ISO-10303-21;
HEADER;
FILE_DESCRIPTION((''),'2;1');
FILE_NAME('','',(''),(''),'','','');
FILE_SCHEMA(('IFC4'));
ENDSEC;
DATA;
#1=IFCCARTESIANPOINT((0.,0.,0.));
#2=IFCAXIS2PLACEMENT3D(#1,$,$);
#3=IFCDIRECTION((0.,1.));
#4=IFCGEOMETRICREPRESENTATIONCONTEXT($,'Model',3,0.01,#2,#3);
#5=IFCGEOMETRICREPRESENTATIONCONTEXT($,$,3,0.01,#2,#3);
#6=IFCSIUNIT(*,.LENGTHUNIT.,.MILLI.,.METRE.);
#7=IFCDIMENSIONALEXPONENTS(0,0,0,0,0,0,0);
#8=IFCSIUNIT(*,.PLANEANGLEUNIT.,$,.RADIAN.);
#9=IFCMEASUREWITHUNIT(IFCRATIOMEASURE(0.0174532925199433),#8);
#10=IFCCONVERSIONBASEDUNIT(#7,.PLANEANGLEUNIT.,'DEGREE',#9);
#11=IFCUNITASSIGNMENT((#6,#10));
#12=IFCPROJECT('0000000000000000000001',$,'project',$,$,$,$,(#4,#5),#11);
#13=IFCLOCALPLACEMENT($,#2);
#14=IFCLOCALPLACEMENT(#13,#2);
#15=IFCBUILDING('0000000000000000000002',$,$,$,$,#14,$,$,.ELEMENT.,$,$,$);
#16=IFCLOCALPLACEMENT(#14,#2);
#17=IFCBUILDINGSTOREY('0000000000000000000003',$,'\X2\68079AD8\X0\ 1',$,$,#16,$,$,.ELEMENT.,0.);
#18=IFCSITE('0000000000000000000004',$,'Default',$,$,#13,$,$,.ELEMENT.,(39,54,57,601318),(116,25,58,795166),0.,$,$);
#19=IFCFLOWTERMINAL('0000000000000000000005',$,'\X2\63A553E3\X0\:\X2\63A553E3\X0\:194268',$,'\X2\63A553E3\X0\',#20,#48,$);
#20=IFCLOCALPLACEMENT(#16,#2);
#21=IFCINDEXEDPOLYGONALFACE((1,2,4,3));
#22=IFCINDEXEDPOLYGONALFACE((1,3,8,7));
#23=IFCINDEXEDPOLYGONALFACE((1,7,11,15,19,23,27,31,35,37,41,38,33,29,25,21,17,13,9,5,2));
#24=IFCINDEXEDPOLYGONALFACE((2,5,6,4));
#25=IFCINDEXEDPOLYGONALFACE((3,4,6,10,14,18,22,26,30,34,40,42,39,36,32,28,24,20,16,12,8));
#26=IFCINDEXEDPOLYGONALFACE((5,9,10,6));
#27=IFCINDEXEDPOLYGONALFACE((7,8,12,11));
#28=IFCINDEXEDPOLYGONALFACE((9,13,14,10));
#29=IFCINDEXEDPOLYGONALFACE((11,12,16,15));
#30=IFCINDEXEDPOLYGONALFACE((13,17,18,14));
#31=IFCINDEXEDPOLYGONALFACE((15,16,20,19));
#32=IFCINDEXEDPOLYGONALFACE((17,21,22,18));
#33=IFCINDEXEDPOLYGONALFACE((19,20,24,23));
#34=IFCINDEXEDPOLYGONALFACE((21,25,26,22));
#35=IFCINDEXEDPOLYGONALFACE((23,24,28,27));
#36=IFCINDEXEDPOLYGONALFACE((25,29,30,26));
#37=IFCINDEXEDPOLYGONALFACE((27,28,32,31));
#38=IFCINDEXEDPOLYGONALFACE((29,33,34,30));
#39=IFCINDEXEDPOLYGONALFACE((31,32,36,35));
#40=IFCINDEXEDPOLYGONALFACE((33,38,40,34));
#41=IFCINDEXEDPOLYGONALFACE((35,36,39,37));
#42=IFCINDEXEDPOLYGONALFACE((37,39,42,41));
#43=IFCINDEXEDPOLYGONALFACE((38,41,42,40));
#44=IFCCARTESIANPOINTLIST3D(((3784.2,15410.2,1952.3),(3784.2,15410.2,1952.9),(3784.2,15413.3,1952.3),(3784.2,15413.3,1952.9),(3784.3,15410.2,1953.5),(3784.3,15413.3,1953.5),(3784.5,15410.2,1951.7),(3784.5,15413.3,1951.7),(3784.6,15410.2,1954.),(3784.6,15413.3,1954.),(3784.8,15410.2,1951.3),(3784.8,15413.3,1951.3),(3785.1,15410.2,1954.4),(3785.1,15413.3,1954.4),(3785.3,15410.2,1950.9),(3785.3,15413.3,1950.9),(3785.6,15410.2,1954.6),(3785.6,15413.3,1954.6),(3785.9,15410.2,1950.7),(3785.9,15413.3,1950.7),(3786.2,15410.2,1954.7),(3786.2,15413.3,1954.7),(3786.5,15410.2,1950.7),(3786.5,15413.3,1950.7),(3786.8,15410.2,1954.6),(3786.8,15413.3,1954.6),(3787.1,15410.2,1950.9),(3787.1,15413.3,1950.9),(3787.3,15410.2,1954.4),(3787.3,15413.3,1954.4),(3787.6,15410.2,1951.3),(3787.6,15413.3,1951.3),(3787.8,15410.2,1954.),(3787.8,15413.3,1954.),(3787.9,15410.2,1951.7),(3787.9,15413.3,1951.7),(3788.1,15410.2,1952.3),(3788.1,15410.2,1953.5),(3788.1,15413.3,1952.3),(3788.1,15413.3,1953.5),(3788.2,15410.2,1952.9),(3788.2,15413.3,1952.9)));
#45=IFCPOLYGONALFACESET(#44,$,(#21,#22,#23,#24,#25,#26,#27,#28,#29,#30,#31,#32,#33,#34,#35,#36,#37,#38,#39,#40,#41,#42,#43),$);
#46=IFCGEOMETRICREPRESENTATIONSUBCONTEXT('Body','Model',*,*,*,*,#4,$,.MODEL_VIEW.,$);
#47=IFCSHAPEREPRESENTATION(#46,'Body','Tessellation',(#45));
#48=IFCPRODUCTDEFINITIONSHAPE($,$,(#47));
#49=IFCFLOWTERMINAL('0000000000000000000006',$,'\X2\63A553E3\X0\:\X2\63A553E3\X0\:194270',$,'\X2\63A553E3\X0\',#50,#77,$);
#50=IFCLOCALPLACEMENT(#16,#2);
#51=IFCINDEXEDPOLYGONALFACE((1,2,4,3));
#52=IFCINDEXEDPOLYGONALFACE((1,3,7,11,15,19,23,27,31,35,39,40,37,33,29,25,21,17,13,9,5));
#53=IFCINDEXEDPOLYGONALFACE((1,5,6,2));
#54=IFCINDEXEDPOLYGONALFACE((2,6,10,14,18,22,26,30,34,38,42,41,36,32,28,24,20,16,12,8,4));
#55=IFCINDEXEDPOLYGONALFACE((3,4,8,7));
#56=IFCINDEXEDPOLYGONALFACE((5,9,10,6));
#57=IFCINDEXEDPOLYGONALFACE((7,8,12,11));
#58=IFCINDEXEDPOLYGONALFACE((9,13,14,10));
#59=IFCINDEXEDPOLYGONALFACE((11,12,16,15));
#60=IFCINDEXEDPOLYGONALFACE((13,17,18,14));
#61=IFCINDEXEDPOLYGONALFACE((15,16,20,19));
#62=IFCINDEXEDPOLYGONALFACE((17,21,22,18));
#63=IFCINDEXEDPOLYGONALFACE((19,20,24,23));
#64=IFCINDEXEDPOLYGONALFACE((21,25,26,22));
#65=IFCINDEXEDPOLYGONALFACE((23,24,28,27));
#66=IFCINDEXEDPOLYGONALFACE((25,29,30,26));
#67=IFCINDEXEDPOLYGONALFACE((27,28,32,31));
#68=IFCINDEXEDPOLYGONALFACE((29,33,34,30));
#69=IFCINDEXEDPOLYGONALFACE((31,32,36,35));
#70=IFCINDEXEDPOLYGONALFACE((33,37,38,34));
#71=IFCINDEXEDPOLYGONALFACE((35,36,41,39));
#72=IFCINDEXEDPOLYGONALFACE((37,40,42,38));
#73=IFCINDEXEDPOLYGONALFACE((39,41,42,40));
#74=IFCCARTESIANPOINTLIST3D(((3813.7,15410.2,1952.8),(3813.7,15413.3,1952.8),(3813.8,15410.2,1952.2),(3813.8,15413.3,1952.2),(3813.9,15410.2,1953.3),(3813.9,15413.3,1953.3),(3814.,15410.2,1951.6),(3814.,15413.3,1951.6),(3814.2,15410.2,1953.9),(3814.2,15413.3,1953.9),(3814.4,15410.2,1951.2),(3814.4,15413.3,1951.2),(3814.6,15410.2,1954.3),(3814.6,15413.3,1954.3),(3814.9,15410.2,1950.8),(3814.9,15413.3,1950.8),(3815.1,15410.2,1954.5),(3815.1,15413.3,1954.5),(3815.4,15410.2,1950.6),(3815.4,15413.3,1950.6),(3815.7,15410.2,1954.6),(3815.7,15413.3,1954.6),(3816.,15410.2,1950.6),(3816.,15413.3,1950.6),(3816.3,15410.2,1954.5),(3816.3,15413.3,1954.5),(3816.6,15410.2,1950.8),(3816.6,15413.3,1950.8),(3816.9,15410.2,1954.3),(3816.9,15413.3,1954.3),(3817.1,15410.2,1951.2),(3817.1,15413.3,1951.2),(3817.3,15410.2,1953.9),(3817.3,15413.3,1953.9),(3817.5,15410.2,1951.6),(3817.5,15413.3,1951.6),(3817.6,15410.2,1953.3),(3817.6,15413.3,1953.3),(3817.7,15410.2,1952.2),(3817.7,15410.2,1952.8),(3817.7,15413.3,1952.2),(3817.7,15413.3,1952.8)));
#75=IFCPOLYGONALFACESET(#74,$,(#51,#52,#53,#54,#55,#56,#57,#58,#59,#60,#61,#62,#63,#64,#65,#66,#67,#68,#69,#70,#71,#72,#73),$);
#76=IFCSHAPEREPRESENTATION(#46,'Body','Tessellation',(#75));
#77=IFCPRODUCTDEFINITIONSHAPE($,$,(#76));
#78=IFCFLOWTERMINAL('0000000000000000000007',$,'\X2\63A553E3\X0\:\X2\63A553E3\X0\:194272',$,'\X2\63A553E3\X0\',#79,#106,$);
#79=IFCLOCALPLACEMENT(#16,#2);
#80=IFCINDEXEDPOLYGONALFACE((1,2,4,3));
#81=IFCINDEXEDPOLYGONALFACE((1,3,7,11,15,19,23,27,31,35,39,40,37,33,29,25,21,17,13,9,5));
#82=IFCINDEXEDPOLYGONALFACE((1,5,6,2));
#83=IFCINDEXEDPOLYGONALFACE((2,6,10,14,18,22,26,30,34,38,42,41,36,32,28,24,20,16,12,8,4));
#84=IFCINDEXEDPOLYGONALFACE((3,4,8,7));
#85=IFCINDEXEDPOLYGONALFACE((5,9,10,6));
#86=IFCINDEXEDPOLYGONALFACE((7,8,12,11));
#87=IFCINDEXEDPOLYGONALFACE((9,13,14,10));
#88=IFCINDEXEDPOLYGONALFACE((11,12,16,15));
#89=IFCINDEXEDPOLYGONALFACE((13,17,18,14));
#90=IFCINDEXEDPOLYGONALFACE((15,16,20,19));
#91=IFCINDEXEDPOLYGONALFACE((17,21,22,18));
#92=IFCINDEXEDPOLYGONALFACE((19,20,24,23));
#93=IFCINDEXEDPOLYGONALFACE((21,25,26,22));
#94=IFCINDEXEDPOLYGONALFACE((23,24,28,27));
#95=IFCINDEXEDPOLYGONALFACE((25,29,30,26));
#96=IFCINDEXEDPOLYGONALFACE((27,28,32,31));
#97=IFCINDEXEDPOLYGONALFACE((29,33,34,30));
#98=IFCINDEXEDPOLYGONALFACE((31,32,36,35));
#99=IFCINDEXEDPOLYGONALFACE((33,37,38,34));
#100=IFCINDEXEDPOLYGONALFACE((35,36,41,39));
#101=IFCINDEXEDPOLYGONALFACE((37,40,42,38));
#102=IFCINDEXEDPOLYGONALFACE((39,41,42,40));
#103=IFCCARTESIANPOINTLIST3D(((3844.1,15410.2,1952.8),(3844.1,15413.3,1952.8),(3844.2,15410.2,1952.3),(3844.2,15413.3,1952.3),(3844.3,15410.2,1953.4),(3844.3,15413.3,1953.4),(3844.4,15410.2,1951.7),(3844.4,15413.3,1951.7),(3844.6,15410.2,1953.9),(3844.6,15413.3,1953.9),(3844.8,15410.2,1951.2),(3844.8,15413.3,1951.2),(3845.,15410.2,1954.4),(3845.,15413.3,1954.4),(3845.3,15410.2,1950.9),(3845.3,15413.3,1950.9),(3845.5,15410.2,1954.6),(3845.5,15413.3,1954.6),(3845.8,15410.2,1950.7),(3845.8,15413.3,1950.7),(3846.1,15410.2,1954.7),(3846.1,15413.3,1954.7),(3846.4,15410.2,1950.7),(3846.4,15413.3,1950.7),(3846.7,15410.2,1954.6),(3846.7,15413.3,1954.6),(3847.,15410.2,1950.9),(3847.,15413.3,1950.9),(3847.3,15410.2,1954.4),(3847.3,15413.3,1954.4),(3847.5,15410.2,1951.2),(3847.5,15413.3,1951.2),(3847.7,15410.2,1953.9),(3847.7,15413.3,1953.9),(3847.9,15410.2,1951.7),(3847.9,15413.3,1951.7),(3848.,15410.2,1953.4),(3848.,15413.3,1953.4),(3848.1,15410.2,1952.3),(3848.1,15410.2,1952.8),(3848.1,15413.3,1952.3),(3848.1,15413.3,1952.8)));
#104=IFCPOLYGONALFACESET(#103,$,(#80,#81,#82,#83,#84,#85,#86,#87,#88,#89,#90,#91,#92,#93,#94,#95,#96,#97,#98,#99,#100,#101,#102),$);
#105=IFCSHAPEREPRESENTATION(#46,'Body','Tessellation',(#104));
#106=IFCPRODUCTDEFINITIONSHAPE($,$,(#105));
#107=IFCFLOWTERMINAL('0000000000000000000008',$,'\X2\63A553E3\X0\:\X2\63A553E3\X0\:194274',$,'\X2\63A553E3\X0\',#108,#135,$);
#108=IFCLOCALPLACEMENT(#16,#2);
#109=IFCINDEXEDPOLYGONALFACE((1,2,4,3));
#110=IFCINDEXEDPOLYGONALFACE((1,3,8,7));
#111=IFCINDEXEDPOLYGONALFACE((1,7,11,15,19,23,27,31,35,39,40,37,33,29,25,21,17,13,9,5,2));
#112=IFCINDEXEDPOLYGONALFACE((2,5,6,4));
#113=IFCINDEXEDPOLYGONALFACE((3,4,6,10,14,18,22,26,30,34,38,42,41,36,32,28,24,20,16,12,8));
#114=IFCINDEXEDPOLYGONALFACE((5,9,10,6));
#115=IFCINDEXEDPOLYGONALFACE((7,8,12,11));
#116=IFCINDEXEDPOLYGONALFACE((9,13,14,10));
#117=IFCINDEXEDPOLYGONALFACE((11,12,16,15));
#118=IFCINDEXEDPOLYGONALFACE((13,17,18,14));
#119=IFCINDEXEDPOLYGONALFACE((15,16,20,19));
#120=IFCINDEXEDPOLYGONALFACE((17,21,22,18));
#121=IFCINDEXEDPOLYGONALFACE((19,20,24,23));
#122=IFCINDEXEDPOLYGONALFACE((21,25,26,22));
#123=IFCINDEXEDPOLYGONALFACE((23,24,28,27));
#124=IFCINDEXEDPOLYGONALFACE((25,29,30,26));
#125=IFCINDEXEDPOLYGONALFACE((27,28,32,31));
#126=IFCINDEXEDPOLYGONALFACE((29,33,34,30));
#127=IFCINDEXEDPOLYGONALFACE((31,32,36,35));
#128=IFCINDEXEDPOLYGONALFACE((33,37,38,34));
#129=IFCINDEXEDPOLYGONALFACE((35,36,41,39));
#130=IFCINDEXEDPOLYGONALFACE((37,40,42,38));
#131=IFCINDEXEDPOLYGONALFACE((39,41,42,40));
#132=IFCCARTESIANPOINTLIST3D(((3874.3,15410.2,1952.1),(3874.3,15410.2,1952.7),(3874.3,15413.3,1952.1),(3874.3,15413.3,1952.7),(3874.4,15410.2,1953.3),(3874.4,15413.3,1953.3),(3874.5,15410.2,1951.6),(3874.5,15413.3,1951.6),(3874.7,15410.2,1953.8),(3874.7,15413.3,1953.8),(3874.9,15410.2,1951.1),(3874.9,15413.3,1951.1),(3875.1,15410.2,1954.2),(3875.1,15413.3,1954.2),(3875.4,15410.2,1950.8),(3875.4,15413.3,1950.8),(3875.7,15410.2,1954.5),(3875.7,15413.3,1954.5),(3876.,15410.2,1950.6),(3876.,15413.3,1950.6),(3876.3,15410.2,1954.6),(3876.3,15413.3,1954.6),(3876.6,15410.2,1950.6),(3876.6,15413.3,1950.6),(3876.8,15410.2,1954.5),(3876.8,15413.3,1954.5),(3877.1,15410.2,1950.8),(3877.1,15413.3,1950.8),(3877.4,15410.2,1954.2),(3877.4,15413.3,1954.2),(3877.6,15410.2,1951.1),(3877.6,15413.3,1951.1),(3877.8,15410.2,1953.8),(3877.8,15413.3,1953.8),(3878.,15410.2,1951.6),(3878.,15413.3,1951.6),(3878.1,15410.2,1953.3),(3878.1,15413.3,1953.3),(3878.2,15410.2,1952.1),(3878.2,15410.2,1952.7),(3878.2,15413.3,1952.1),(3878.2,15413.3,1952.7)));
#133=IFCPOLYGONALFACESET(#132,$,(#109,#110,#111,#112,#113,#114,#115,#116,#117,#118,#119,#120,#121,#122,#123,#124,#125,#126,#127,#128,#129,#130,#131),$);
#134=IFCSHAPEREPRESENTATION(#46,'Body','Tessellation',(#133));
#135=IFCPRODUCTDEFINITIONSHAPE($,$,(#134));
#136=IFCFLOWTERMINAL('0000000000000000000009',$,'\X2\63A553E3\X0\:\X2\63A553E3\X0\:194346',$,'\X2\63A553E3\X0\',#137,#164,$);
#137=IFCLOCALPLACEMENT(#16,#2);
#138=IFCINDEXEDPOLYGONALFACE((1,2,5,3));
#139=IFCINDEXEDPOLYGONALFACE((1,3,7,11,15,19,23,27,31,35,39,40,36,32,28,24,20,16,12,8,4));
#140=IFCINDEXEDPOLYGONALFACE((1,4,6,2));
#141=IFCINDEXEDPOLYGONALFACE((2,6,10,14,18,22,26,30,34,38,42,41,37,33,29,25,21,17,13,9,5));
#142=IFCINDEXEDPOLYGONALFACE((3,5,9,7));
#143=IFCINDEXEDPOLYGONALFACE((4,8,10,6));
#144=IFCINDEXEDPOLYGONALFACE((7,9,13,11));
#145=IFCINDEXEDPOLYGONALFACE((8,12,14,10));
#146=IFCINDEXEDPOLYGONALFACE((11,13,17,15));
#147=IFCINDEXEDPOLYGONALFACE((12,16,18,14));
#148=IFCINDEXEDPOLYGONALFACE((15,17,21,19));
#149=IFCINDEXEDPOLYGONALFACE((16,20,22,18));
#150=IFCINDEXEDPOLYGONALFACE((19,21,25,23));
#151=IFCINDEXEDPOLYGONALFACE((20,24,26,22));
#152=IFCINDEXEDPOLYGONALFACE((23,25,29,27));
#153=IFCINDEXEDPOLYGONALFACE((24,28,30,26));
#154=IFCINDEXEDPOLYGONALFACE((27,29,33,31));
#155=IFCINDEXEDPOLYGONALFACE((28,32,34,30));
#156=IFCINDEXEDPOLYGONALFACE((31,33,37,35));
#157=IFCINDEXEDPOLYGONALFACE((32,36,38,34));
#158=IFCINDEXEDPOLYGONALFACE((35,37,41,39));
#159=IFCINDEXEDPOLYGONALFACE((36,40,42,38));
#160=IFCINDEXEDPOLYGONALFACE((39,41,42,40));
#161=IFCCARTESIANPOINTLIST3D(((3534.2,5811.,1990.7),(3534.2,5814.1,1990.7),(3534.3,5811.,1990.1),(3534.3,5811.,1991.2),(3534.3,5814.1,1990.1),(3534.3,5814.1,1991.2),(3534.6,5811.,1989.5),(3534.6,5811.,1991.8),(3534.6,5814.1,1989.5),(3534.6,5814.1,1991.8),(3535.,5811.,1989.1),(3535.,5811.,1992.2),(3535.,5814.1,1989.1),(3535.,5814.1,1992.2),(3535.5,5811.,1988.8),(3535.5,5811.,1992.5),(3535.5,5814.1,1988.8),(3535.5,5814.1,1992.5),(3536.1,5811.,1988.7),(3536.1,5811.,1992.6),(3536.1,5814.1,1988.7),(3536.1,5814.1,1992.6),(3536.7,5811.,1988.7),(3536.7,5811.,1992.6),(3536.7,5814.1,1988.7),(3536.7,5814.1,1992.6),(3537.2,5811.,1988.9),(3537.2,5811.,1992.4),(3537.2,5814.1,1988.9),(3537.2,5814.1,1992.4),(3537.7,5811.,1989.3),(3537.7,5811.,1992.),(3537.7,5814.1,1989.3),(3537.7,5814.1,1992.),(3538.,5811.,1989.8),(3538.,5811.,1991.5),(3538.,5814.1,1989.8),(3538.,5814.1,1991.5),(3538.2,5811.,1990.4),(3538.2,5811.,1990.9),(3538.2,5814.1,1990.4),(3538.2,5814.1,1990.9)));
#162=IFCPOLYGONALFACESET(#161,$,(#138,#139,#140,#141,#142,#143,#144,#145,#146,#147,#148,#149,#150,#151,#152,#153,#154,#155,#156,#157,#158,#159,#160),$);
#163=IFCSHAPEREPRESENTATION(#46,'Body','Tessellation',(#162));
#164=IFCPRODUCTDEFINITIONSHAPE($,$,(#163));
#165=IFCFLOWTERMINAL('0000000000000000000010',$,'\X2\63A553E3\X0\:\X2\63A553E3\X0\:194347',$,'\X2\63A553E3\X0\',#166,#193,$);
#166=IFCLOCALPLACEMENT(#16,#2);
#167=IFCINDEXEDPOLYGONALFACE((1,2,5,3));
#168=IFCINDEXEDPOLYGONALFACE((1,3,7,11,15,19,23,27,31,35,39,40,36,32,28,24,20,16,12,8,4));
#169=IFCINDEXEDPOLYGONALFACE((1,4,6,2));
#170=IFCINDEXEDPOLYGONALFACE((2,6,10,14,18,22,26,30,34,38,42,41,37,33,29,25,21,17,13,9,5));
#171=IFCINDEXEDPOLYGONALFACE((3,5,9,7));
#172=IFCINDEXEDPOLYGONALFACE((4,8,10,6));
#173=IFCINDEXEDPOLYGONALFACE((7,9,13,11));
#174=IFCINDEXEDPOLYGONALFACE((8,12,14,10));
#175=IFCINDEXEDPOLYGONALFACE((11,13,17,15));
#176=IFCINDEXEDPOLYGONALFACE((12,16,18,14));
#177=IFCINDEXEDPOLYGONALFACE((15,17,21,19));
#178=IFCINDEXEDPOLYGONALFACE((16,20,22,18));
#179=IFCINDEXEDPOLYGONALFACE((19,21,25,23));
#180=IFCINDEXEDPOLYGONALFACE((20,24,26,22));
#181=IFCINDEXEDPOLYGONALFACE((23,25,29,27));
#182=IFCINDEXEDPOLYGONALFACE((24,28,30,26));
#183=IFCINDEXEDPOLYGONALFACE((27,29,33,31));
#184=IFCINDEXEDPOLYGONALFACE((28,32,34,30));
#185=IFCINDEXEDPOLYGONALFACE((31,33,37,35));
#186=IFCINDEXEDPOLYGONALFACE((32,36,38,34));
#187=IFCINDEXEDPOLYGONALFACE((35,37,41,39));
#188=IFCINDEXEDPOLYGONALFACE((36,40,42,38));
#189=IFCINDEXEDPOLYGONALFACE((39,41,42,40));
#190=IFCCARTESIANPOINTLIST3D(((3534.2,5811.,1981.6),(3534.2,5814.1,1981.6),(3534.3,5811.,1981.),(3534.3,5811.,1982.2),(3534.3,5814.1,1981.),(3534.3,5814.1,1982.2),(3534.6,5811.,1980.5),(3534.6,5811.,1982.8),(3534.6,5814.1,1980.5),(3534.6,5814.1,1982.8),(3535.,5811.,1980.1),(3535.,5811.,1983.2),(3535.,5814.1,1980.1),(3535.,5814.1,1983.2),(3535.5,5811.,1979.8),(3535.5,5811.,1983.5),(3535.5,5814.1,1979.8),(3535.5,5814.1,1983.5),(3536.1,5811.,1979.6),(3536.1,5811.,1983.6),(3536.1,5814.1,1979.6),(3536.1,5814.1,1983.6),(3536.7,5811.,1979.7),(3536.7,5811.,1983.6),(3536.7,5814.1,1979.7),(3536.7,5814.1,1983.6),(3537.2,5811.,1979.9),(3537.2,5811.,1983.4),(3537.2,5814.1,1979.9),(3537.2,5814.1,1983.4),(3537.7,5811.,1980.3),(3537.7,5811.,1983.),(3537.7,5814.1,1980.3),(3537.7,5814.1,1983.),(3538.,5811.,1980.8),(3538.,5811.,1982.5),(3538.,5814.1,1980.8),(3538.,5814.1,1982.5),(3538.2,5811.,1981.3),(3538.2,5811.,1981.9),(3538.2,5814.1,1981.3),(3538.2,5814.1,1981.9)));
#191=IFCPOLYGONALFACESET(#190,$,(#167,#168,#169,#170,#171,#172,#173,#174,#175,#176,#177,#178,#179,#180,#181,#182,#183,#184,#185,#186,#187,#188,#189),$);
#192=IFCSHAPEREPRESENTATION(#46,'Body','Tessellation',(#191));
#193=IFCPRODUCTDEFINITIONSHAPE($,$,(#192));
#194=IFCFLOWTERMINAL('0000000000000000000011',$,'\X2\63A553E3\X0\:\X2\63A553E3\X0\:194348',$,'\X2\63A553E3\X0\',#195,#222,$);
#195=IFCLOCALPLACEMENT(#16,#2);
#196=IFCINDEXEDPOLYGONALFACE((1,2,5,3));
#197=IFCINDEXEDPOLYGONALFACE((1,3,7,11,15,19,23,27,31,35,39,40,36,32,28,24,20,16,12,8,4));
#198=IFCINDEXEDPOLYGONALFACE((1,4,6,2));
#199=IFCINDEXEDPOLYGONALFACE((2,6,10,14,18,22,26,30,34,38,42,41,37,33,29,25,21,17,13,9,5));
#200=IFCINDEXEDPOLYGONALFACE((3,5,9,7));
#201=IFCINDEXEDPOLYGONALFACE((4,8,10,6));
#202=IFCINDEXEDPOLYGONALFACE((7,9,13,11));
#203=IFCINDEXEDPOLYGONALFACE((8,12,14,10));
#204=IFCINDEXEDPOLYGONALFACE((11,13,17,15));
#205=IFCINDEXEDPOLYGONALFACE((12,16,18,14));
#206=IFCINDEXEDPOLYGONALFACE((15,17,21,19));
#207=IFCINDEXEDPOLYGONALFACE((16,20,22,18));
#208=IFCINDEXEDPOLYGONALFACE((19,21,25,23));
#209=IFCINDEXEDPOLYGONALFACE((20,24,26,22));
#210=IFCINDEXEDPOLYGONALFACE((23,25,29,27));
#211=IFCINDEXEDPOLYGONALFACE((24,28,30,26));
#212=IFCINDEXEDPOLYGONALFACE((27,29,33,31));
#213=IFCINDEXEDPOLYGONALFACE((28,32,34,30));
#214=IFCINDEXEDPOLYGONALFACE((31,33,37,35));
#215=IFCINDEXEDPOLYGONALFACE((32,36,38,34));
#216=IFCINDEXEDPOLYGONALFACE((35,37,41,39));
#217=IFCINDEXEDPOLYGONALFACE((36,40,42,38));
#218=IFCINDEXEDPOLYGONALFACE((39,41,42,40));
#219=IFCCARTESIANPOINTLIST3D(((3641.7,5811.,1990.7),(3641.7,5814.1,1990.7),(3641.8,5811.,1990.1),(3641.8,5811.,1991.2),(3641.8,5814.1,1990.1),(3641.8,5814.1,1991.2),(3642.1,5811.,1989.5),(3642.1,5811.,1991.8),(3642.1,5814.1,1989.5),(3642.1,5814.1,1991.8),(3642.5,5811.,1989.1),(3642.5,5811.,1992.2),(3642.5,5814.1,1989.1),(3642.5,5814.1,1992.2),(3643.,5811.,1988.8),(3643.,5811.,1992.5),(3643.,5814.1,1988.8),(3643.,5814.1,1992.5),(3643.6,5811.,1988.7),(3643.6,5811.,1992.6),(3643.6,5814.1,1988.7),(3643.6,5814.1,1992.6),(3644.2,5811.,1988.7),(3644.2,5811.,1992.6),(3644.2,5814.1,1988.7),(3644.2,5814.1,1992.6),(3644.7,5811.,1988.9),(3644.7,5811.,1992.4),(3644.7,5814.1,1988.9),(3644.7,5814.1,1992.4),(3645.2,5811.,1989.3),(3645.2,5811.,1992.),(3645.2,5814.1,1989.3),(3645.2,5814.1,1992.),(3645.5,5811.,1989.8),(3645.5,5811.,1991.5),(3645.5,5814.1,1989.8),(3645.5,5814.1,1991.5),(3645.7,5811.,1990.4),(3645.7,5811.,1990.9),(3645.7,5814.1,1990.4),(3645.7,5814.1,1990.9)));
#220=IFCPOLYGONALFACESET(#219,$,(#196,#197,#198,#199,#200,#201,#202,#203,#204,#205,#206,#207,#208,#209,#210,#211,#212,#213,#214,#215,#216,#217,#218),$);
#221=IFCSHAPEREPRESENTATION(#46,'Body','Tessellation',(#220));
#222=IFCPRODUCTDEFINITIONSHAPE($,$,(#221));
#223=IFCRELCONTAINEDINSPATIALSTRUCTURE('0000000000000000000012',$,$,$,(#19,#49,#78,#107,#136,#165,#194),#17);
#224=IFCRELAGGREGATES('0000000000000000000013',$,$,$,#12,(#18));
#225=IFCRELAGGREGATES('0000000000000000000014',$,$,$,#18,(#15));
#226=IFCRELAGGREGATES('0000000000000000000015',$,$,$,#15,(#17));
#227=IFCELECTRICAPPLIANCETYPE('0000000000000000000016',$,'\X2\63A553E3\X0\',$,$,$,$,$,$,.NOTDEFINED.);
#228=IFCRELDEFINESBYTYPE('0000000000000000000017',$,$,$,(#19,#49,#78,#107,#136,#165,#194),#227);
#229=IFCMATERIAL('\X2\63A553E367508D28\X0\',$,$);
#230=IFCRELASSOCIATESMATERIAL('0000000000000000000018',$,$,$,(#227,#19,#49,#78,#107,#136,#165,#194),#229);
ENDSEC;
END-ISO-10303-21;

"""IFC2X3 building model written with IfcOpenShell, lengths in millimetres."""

from ifc_helpers import new_model, entity, si_unit, converted_unit, direction, frame, frame_2d, origin, place, context, subcontext, project, spatial, circle, extrude, source, transform, mapped, material, type_object, type_shapes, element, save


model = new_model("IFC2X3")

# Units and contexts
model_context = context("Model", 3, precision=0.01, world=origin(), true_north=direction((0.0, 1.0)))
context_of_model = context(None, 3, precision=0.01, world=origin(), true_north=direction((0.0, 1.0)))
body_context = subcontext(model_context, "Body", "Model", "MODEL_VIEW")
ifc_project = project(units=[si_unit("LENGTHUNIT", "METRE", prefix="MILLI"), converted_unit("PLANEANGLEUNIT", "DEGREE", entity("IfcRatioMeasure", 0.0174532925199433), si_unit("PLANEANGLEUNIT", "RADIAN"), dimensions=[0, 0, 0, 0, 0, 0, 0])], contexts=[model_context, context_of_model])

# Site, building, storey
site_placement = place(None, origin())
site = spatial("IfcSite", under=ifc_project, at=site_placement, Name="Default", CompositionType="ELEMENT", RefLatitude=(39, 54, 57, 601318), RefLongitude=(116, 25, 58, 795166), RefElevation=0.0)
building_placement = place(site_placement, origin())
building = spatial("IfcBuilding", under=site, at=building_placement, CompositionType="ELEMENT")
storey_placement = place(building_placement, origin())
storey = spatial("IfcBuildingStorey", under=building, at=storey_placement, Name="标高 1", CompositionType="ELEMENT", Elevation=0.0)

# Flow terminals
ifc_material = material(Name="接口材质")
electric_appliance_type = type_object("IfcElectricApplianceType", Name="接口", PredefinedType="NOTDEFINED", material=ifc_material)
shared_shape = source(origin(), body_context, "Body", "SweptSolid", [
    extrude(circle(Radius=2.0, at=frame_2d((0.0, 0.0), x_axis=(1.0, 0.0))), origin(), (0.0, 0.0, 1.0), 3.1),
])
type_shapes(electric_appliance_type, [shared_shape])
for number, where, z_axis, x_axis, name in (
    (1, (3786.2, 15413.3, 1952.7), (0.0, -1.0, 0.0), (0.0, 0.0, 1.0), "接口:接口:194268"),
    (2, (3815.7, 15413.3, 1952.6), (0.0, -1.0, 0.0), (0.0, 0.0, 1.0), "接口:接口:194270"),
    (3, (3846.1, 15413.3, 1952.7), (0.0, -1.0, 0.0), (0.0, 0.0, 1.0), "接口:接口:194272"),
    (4, (3876.3, 15413.3, 1952.6), (0.0, -1.0, 0.0), (0.0, 0.0, 1.0), "接口:接口:194274"),
    (5, (3536.2, 5814.1, 1990.7), (0.0, -1.0, 0.0), (-1.0, 0.0, 0.0), "接口:接口:194346"),
    (6, (3536.2, 5814.1, 1981.6), (0.0, -1.0, 0.0), (-1.0, 0.0, 0.0), "接口:接口:194347"),
    (7, (3643.7, 5814.1, 1990.7), (0.0, -1.0, 0.0), (-1.0, 0.0, 0.0), "接口:接口:194348"),
):
    element("IfcFlowTerminal", number, at=place(storey_placement, frame(where, z_axis=z_axis, x_axis=x_axis)), inside=storey, type_object=electric_appliance_type, material=ifc_material, Name=name, ObjectType="接口", context=body_context, shape_type="MappedRepresentation", body=[
        mapped(shared_shape, transform((0.0, 0.0, 0.0), scale=1.0)),
    ])

save(model, "model.ifc")
